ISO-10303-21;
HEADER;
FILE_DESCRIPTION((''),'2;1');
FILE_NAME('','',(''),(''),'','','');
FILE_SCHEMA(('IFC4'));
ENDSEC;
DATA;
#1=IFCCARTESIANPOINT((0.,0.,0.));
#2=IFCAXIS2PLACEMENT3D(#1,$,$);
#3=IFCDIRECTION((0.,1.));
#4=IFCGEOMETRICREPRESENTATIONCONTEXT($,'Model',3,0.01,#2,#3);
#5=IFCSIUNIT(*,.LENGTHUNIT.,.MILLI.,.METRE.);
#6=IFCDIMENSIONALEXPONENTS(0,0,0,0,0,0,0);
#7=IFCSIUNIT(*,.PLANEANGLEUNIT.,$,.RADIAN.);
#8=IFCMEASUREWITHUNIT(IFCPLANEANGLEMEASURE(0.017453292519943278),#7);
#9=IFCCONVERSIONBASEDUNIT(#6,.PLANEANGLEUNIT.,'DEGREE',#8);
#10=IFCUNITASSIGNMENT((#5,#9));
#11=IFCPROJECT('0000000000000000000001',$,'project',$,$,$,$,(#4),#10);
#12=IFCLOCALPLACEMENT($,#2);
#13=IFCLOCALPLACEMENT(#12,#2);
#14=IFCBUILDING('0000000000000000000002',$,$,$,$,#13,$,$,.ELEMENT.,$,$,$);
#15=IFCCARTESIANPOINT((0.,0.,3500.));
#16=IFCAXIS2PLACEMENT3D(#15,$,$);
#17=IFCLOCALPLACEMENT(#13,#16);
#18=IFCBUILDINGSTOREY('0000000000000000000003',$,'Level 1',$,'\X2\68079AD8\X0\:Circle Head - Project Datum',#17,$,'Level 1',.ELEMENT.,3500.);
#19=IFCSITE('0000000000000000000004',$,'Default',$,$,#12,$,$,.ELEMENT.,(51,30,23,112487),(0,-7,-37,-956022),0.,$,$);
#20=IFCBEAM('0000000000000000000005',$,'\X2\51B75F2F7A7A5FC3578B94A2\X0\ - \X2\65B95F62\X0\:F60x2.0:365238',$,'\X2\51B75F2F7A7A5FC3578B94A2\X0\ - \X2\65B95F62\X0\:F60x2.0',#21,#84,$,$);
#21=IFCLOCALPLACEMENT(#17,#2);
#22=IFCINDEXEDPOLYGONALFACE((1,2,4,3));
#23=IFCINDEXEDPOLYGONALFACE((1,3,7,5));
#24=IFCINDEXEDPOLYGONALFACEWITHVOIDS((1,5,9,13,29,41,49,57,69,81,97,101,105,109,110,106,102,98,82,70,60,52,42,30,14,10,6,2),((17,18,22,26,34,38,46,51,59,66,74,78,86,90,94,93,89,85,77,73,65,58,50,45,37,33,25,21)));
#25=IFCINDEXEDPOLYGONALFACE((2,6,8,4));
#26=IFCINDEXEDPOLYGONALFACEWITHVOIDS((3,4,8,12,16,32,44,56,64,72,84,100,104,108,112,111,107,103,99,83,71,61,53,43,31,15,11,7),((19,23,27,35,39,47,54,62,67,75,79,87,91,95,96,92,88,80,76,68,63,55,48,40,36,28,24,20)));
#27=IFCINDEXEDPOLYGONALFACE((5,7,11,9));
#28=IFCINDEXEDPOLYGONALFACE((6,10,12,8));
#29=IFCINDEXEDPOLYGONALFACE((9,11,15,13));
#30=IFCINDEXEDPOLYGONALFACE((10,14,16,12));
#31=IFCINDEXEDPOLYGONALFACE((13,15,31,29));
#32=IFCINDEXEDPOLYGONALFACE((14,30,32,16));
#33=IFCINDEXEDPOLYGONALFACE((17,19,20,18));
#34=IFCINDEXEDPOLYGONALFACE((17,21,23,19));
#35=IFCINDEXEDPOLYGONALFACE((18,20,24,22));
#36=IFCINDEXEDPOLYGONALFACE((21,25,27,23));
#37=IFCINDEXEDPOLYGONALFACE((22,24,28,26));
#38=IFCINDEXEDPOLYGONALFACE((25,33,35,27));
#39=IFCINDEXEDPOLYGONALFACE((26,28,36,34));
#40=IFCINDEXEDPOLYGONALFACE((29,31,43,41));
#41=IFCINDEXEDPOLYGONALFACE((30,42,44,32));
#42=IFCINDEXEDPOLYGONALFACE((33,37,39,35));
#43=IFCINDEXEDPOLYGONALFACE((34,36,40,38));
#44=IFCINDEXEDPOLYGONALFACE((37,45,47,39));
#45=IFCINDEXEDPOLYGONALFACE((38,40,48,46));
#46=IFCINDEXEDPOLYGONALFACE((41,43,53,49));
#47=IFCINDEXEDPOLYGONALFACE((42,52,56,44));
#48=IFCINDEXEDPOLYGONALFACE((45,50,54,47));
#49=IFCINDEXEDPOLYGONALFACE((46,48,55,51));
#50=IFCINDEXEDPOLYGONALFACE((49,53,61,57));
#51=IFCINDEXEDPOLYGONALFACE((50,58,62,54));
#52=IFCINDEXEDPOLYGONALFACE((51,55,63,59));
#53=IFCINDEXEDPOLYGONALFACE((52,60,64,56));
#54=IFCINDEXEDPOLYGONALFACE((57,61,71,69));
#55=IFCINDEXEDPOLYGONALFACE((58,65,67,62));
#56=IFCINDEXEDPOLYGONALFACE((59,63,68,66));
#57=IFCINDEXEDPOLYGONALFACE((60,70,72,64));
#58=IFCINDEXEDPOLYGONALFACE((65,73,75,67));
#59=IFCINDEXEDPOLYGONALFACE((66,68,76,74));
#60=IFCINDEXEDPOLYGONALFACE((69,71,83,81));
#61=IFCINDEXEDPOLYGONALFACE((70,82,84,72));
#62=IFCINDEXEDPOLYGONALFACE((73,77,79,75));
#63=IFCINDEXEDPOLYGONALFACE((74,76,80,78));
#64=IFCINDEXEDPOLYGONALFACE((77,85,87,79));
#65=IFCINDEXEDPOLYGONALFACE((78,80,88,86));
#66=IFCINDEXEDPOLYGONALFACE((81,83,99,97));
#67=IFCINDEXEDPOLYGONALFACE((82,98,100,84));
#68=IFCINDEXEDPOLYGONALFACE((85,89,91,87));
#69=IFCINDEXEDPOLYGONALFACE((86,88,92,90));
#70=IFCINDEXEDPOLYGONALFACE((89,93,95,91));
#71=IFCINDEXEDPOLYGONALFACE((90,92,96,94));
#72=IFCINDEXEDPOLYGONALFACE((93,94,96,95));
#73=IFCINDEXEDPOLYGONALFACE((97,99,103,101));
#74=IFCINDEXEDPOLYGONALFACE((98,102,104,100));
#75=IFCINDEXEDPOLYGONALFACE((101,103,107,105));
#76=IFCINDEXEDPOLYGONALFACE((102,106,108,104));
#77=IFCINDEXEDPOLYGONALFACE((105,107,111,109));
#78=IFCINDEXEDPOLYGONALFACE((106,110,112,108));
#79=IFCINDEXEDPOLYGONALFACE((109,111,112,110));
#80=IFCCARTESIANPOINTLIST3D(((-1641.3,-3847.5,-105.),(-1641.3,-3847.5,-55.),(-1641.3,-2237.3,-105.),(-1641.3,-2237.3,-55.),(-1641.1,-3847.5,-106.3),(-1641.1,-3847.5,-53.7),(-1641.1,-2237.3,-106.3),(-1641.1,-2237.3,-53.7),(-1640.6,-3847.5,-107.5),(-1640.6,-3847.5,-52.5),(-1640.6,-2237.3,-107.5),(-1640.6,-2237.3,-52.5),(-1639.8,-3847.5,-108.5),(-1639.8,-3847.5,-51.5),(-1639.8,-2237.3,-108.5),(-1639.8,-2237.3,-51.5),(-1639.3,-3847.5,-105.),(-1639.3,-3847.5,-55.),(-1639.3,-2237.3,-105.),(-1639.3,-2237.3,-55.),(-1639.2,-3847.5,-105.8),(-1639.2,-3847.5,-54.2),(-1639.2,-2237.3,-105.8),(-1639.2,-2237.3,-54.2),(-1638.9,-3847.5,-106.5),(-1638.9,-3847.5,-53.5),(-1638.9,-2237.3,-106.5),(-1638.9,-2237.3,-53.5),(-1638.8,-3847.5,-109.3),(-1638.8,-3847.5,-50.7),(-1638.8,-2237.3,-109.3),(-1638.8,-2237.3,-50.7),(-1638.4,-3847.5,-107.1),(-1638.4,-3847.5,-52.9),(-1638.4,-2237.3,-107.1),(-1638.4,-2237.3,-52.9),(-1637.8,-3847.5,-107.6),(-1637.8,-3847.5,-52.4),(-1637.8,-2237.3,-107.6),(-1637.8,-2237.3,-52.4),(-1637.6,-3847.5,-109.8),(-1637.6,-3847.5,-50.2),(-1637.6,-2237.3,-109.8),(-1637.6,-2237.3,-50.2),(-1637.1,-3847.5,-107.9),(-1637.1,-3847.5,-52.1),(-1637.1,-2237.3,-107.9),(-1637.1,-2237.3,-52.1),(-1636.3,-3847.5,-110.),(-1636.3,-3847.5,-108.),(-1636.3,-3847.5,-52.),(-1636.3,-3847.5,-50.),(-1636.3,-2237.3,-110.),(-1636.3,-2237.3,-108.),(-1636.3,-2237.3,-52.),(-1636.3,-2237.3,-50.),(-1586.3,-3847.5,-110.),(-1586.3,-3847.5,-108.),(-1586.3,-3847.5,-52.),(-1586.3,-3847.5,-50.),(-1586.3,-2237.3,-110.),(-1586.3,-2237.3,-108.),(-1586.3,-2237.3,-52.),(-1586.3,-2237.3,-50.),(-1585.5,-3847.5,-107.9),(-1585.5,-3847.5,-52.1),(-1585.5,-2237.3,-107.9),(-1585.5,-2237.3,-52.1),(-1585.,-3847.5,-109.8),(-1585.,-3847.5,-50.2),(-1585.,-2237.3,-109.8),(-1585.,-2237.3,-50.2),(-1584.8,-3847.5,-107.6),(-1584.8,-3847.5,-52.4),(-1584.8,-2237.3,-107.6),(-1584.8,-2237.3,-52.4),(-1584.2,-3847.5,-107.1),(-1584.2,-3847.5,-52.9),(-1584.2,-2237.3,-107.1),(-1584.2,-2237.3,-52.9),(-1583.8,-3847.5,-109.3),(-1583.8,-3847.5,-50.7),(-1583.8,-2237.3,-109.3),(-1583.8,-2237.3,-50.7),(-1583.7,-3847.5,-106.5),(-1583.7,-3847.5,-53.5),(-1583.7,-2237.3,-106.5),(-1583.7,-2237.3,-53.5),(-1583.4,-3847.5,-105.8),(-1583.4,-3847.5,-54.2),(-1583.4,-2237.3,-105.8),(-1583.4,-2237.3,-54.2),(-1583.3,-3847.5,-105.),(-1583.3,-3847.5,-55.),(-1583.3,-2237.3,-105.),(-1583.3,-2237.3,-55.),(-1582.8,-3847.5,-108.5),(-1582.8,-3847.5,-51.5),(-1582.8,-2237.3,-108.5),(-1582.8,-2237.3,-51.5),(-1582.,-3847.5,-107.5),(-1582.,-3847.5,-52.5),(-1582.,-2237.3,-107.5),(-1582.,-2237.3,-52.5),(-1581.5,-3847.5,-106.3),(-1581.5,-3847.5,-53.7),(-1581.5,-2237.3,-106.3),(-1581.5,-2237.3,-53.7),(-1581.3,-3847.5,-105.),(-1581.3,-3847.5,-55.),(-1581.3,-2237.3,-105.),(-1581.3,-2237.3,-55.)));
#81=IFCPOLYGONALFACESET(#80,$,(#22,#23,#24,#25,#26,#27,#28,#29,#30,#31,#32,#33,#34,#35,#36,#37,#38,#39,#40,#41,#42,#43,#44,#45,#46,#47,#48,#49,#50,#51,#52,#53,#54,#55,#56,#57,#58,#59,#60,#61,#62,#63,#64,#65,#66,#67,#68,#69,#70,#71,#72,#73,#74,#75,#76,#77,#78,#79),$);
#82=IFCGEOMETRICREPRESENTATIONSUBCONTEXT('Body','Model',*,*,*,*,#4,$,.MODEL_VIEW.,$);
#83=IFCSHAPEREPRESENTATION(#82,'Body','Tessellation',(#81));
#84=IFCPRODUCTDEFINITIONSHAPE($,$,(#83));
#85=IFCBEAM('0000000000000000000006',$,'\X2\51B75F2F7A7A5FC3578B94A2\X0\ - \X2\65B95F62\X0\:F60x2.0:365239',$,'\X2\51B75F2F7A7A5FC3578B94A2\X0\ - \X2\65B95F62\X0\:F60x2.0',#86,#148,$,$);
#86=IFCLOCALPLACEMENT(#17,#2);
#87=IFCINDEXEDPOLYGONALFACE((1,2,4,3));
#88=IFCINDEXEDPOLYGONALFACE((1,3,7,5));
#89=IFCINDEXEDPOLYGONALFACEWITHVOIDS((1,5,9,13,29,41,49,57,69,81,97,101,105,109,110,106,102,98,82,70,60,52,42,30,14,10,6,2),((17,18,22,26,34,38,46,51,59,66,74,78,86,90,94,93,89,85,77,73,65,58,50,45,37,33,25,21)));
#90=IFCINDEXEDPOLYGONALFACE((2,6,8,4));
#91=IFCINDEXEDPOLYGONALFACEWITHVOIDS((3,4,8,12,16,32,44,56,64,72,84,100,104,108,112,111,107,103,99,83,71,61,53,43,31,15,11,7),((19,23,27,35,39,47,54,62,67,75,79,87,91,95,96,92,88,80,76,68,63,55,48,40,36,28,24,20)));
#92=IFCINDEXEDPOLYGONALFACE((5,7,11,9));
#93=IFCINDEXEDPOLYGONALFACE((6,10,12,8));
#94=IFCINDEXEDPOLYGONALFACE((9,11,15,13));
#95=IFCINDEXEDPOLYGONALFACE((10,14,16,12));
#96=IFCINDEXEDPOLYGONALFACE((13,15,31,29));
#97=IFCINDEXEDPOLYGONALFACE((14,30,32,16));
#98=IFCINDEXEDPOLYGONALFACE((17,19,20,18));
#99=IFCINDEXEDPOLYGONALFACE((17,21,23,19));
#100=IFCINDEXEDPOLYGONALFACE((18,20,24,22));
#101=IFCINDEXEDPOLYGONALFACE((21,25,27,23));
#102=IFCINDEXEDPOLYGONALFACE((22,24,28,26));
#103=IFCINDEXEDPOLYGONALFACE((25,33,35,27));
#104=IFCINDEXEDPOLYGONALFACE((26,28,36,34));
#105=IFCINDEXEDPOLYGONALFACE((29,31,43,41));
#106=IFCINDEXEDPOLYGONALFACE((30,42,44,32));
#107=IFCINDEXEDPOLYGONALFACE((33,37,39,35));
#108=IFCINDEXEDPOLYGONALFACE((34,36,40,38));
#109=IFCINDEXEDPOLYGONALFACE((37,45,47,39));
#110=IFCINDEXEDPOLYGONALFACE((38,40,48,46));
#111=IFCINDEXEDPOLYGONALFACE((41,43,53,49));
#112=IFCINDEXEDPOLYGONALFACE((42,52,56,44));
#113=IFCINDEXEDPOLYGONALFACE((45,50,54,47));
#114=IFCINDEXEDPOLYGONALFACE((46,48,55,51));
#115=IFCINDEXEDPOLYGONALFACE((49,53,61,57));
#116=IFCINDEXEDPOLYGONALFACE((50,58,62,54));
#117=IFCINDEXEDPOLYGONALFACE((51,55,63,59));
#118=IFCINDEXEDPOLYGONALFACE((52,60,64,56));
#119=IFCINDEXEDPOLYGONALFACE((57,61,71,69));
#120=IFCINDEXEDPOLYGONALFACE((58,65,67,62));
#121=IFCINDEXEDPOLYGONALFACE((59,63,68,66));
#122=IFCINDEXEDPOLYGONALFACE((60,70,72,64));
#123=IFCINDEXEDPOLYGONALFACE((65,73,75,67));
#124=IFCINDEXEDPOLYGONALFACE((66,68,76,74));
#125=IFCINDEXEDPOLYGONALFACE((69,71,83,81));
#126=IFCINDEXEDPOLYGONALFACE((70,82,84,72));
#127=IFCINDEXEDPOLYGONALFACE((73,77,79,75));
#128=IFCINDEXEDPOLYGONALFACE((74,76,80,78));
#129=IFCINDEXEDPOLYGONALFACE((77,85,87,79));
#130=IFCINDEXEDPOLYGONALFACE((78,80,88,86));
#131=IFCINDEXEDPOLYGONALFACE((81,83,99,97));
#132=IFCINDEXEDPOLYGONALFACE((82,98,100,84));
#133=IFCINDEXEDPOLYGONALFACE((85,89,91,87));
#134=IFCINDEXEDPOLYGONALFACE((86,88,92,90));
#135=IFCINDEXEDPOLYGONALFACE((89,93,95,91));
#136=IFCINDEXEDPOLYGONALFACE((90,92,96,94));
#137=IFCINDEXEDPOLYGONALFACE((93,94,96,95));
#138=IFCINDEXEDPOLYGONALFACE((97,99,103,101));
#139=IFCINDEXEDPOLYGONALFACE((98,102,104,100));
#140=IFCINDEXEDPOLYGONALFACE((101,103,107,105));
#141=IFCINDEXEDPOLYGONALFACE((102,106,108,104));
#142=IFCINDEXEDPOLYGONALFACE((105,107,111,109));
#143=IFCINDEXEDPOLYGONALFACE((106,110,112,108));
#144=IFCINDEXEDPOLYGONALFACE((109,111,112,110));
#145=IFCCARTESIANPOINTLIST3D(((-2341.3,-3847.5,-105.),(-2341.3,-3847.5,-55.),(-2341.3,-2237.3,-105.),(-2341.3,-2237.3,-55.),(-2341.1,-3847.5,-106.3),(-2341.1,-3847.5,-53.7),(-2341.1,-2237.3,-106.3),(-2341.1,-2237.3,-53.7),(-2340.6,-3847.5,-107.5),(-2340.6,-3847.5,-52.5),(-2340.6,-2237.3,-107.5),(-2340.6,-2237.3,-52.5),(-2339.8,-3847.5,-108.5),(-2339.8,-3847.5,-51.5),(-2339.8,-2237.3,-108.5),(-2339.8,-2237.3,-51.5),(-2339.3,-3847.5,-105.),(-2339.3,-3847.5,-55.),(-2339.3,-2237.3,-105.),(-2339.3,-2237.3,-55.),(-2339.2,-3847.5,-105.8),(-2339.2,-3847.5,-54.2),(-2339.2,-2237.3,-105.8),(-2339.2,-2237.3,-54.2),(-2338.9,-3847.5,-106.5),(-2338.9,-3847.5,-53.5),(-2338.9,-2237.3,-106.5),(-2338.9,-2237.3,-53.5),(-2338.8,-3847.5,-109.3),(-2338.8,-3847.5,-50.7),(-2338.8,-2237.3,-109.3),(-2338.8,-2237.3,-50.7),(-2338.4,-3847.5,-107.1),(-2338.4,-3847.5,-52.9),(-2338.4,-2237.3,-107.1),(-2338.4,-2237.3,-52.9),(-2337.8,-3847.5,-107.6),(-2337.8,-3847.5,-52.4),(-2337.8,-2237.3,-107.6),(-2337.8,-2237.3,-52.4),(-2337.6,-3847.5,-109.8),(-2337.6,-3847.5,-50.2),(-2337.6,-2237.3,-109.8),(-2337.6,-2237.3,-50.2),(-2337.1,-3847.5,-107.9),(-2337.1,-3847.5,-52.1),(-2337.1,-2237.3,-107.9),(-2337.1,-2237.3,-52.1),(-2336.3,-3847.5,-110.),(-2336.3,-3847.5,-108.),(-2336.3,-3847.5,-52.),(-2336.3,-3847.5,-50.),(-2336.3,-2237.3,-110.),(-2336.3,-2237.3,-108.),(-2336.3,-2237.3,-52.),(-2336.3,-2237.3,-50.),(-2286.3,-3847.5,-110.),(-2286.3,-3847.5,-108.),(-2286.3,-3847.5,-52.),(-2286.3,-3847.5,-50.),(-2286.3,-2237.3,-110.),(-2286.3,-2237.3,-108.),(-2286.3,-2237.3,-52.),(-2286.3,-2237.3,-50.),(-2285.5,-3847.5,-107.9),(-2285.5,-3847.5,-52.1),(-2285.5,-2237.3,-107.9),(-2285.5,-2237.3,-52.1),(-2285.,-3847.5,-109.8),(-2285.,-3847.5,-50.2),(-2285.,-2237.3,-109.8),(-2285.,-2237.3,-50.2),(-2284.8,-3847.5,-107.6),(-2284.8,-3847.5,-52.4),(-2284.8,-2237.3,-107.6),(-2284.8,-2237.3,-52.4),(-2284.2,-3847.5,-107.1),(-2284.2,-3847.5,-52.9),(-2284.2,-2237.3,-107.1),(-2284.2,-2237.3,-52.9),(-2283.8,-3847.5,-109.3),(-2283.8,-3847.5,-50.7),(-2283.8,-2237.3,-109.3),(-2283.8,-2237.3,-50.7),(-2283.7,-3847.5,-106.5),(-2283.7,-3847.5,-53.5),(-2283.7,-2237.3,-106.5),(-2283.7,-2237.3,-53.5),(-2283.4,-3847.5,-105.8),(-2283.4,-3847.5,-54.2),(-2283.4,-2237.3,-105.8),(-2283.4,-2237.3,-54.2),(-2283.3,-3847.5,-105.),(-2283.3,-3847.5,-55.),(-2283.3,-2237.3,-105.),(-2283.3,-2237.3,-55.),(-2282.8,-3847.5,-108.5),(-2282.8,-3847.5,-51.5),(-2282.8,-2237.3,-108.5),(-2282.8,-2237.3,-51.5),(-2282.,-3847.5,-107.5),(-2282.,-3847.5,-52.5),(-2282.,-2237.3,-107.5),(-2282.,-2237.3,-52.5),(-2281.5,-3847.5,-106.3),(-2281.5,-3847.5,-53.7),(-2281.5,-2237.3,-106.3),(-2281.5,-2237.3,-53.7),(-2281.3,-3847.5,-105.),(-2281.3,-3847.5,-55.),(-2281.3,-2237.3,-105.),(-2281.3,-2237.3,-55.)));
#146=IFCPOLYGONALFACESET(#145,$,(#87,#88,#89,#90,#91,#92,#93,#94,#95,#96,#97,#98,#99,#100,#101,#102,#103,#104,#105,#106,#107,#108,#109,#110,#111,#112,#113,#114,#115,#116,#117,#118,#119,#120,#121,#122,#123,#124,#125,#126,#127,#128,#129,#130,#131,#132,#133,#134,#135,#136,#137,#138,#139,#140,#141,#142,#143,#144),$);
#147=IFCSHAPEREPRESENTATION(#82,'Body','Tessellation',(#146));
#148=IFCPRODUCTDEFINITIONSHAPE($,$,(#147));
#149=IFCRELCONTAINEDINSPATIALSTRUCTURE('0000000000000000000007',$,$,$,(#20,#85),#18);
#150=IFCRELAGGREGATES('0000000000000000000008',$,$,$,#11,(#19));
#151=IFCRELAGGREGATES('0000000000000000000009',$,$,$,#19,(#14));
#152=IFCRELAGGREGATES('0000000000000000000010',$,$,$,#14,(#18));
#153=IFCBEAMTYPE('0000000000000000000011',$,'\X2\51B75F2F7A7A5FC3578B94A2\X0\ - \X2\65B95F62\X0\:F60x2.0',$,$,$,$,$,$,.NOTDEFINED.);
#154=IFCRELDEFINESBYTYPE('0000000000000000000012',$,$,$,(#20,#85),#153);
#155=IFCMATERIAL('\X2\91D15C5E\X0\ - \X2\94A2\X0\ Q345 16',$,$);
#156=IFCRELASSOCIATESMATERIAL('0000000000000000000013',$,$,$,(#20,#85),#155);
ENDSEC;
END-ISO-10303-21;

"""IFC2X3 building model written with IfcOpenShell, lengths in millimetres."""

from ifc_helpers import new_model, entity, si_unit, converted_unit, direction, frame, frame_2d, origin, place, context, subcontext, project, spatial, polyline, circle_curve, parameter, trimmed, segment, composite_curve, outline, extrude, material, type_object, element, save


model = new_model("IFC2X3")

# Units and contexts
model_context = context("Model", 3, precision=0.01, world=origin(), true_north=direction((0.0, 1.0)))
body_context = subcontext(model_context, "Body", "Model", "MODEL_VIEW")
ifc_project = project(units=[si_unit("LENGTHUNIT", "METRE", prefix="MILLI"), converted_unit("PLANEANGLEUNIT", "DEGREE", entity("IfcPlaneAngleMeasure", 0.017453292519943278), si_unit("PLANEANGLEUNIT", "RADIAN"), dimensions=[0, 0, 0, 0, 0, 0, 0])], contexts=[model_context])

# Site, building, storey
site_placement = place(None, origin())
site = spatial("IfcSite", under=ifc_project, at=site_placement, Name="Default", CompositionType="ELEMENT", RefLatitude=(51, 30, 23, 112487), RefLongitude=(0, -7, -37, -956022), RefElevation=0.0)
building_placement = place(site_placement, origin())
building = spatial("IfcBuilding", under=site, at=building_placement, CompositionType="ELEMENT")
storey_placement = place(building_placement, frame((0.0, 0.0, 3500.0)))
storey = spatial("IfcBuildingStorey", under=building, at=storey_placement, Name="Level 1", ObjectType="标高:Circle Head - Project Datum", LongName="Level 1", CompositionType="ELEMENT", Elevation=3500.0)

# Beams
ifc_material_1 = material(Name="金属 - 钢 Q345 16")
beam_type_1 = type_object("IfcBeamType", Name="冷弯空心型钢 - 方形:F60x2.0", PredefinedType="NOTDEFINED")
beam_1_placement = place(storey_placement, frame((-1611.3, -3815.6, -50.0), z_axis=(0.0, 0.0, 1.0), x_axis=(0.0, 1.0, 0.0)))
element("IfcBeam", 1, at=beam_1_placement, inside=storey, type_object=beam_type_1, material=ifc_material_1, Name="冷弯空心型钢 - 方形:F60x2.0:365238", ObjectType="冷弯空心型钢 - 方形:F60x2.0", context=body_context, shape_type="SweptSolid", body=[
    extrude(outline(composite_curve([segment(polyline([(-25.0, -30.0), (25.0, -30.0)]), True, "CONTINUOUS"), segment(trimmed(circle_curve(frame_2d((25.0, -25.0), x_axis=(1.0, 0.0)), 5.0), [parameter(270.0)], [parameter(360.0)], True, "PARAMETER"), True, "CONTINUOUS"), segment(polyline([(30.0, -25.0), (30.0, 25.0)]), True, "CONTINUOUS"), segment(trimmed(circle_curve(frame_2d((25.0, 25.0), x_axis=(1.0, 0.0)), 5.0), [parameter(360.0)], [parameter(90.0)], True, "PARAMETER"), True, "CONTINUOUS"), segment(polyline([(25.0, 30.0), (-25.0, 30.0)]), True, "CONTINUOUS"), segment(trimmed(circle_curve(frame_2d((-25.0, 25.0), x_axis=(1.0, 0.0)), 5.0), [parameter(90.0)], [parameter(180.0)], True, "PARAMETER"), True, "CONTINUOUS"), segment(polyline([(-30.0, 25.0), (-30.0, -25.0)]), True, "CONTINUOUS"), segment(trimmed(circle_curve(frame_2d((-25.0, -25.0), x_axis=(1.0, 0.0)), 5.0), [parameter(180.0)], [parameter(270.0)], True, "PARAMETER"), True, "CONTINUOUS")], self_intersect=False), holes=[composite_curve([segment(trimmed(circle_curve(frame_2d((-25.0, -25.0), x_axis=(1.0, 0.0)), 3.0), [parameter(180.0)], [parameter(270.0)], True, "PARAMETER"), False, "CONTINUOUS"), segment(polyline([(-28.0, -25.0), (-28.0, 25.0)]), True, "CONTINUOUS"), segment(trimmed(circle_curve(frame_2d((-25.0, 25.0), x_axis=(1.0, 0.0)), 3.0), [parameter(90.0)], [parameter(180.0)], True, "PARAMETER"), False, "CONTINUOUS"), segment(polyline([(-25.0, 28.0), (25.0, 28.0)]), True, "CONTINUOUS"), segment(trimmed(circle_curve(frame_2d((25.0, 25.0), x_axis=(1.0, 0.0)), 3.0), [parameter(0.0)], [parameter(90.0)], True, "PARAMETER"), False, "CONTINUOUS"), segment(polyline([(28.0, 25.0), (28.0, -25.0)]), True, "CONTINUOUS"), segment(trimmed(circle_curve(frame_2d((25.0, -25.0), x_axis=(1.0, 0.0)), 3.0), [parameter(270.0)], [parameter(360.0)], True, "PARAMETER"), False, "CONTINUOUS"), segment(polyline([(25.0, -28.0), (-25.0, -28.0)]), True, "CONTINUOUS")], self_intersect=False)]), frame((-31.9, 0.0, -30.0), z_axis=(1.0, 0.0, 0.0), x_axis=(0.0, -1.0, 0.0)), (0.0, 0.0, 1.0), 1610.2),
])
beam_2_placement = place(storey_placement, frame((-2311.3, -3815.6, -50.0), z_axis=(0.0, 0.0, 1.0), x_axis=(0.0, 1.0, 0.0)))
element("IfcBeam", 2, at=beam_2_placement, inside=storey, type_object=beam_type_1, material=ifc_material_1, Name="冷弯空心型钢 - 方形:F60x2.0:365239", ObjectType="冷弯空心型钢 - 方形:F60x2.0", context=body_context, shape_type="SweptSolid", body=[
    extrude(outline(composite_curve([segment(polyline([(-25.0, -30.0), (25.0, -30.0)]), True, "CONTINUOUS"), segment(trimmed(circle_curve(frame_2d((25.0, -25.0), x_axis=(1.0, 0.0)), 5.0), [parameter(270.0)], [parameter(360.0)], True, "PARAMETER"), True, "CONTINUOUS"), segment(polyline([(30.0, -25.0), (30.0, 25.0)]), True, "CONTINUOUS"), segment(trimmed(circle_curve(frame_2d((25.0, 25.0), x_axis=(1.0, 0.0)), 5.0), [parameter(360.0)], [parameter(90.0)], True, "PARAMETER"), True, "CONTINUOUS"), segment(polyline([(25.0, 30.0), (-25.0, 30.0)]), True, "CONTINUOUS"), segment(trimmed(circle_curve(frame_2d((-25.0, 25.0), x_axis=(1.0, 0.0)), 5.0), [parameter(90.0)], [parameter(180.0)], True, "PARAMETER"), True, "CONTINUOUS"), segment(polyline([(-30.0, 25.0), (-30.0, -25.0)]), True, "CONTINUOUS"), segment(trimmed(circle_curve(frame_2d((-25.0, -25.0), x_axis=(1.0, 0.0)), 5.0), [parameter(180.0)], [parameter(270.0)], True, "PARAMETER"), True, "CONTINUOUS")], self_intersect=False), holes=[composite_curve([segment(trimmed(circle_curve(frame_2d((-25.0, -25.0), x_axis=(1.0, 0.0)), 3.0), [parameter(180.0)], [parameter(270.0)], True, "PARAMETER"), False, "CONTINUOUS"), segment(polyline([(-28.0, -25.0), (-28.0, 25.0)]), True, "CONTINUOUS"), segment(trimmed(circle_curve(frame_2d((-25.0, 25.0), x_axis=(1.0, 0.0)), 3.0), [parameter(90.0)], [parameter(180.0)], True, "PARAMETER"), False, "CONTINUOUS"), segment(polyline([(-25.0, 28.0), (25.0, 28.0)]), True, "CONTINUOUS"), segment(trimmed(circle_curve(frame_2d((25.0, 25.0), x_axis=(1.0, 0.0)), 3.0), [parameter(0.0)], [parameter(90.0)], True, "PARAMETER"), False, "CONTINUOUS"), segment(polyline([(28.0, 25.0), (28.0, -25.0)]), True, "CONTINUOUS"), segment(trimmed(circle_curve(frame_2d((25.0, -25.0), x_axis=(1.0, 0.0)), 3.0), [parameter(270.0)], [parameter(360.0)], True, "PARAMETER"), False, "CONTINUOUS"), segment(polyline([(25.0, -28.0), (-25.0, -28.0)]), True, "CONTINUOUS")], self_intersect=False)]), frame((-31.9, 0.0, -30.0), z_axis=(1.0, 0.0, 0.0), x_axis=(0.0, -1.0, 0.0)), (0.0, 0.0, 1.0), 1610.2),
])

save(model, "model.ifc")
